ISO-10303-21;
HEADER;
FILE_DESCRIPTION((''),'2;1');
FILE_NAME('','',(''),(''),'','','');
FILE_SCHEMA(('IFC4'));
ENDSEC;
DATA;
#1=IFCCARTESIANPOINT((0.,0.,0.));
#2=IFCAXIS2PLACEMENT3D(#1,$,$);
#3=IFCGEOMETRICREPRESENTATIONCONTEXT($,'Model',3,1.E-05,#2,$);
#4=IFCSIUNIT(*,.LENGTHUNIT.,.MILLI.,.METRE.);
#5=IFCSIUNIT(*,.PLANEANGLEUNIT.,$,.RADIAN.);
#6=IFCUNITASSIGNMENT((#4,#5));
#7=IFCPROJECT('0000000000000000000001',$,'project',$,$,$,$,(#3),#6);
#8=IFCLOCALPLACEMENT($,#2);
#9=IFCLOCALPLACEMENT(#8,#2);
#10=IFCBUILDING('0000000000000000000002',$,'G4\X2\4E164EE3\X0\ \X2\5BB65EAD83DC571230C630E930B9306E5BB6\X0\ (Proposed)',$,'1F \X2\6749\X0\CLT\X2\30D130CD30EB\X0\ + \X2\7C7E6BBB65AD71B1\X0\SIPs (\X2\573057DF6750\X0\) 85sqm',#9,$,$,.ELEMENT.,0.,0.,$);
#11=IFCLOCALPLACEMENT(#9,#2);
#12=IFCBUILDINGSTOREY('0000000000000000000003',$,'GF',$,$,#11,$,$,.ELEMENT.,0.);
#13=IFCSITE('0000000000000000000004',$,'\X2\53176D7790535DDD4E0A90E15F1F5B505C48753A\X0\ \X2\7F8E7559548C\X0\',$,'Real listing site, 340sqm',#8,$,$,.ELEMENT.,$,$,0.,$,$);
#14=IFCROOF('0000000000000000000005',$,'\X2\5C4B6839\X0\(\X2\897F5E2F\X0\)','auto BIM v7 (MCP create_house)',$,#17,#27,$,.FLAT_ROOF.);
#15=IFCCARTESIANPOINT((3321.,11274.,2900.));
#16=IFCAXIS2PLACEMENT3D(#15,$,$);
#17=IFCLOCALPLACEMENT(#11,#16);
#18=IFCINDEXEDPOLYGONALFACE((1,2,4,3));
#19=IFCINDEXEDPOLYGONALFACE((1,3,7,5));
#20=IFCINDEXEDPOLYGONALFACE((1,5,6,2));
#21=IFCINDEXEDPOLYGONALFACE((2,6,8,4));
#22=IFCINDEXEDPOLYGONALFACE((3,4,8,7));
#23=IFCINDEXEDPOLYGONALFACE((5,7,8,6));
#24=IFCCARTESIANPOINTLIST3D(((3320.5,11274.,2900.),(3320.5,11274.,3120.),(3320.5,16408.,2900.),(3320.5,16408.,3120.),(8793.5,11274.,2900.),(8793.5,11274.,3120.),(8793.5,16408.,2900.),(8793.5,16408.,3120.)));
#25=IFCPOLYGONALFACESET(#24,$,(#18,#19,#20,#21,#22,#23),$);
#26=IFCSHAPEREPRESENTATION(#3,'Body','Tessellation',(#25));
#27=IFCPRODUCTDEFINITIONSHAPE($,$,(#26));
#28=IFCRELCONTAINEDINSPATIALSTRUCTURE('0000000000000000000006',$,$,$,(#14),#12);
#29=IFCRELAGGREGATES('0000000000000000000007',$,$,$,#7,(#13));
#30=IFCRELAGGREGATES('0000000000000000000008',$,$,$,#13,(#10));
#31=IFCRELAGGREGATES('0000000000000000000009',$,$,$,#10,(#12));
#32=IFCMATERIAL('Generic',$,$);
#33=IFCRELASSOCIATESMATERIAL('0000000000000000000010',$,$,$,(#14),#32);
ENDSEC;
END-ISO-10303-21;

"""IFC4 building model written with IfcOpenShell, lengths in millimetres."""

from ifc_helpers import new_model, si_unit, frame, frame_2d, origin, place, context, project, spatial, rectangle, extrude, material, element, save


model = new_model("IFC4")

# Units and contexts
model_context = context("Model", 3, precision=1e-05, world=origin())
ifc_project = project(units=[si_unit("LENGTHUNIT", "METRE", prefix="MILLI"), si_unit("PLANEANGLEUNIT", "RADIAN")], contexts=[model_context])

# Site, building, storey
site_placement = place(None, origin())
site = spatial("IfcSite", under=ifc_project, at=site_placement, Name="北海道川上郡弟子屈町 美留和", ObjectType="Real listing site, 340sqm", CompositionType="ELEMENT", RefElevation=0.0)
building_placement = place(site_placement, origin())
building = spatial("IfcBuilding", under=site, at=building_placement, Name="G4世代 家庭菜園テラスの家 (Proposed)", ObjectType="1F 杉CLTパネル + 籾殻断熱SIPs (地域材) 85sqm", CompositionType="ELEMENT", ElevationOfRefHeight=0.0, ElevationOfTerrain=0.0)
storey_placement = place(building_placement, origin())
storey = spatial("IfcBuildingStorey", under=building, at=storey_placement, Name="GF", CompositionType="ELEMENT", Elevation=0.0)

# Shared definitions
ifc_material = material(Name="Generic")

# Roof
roof_1_placement = place(storey_placement, frame((3321.0, 11274.0, 2900.0)))
element("IfcRoof", 1, at=roof_1_placement, inside=storey, material=ifc_material, Name="屋根(西帯)", Description="auto BIM v7 (MCP create_house)", PredefinedType="FLAT_ROOF", context=model_context, shape_type="SweptSolid", body=[
    extrude(rectangle(XDim=5473.0, YDim=5134.0, at=frame_2d((2736.0, 2567.0))), frame((3321.0, 11274.0, 2900.0)), (0.0, 0.0, 1.0), 220.0),
])

save(model, "model.ifc")
